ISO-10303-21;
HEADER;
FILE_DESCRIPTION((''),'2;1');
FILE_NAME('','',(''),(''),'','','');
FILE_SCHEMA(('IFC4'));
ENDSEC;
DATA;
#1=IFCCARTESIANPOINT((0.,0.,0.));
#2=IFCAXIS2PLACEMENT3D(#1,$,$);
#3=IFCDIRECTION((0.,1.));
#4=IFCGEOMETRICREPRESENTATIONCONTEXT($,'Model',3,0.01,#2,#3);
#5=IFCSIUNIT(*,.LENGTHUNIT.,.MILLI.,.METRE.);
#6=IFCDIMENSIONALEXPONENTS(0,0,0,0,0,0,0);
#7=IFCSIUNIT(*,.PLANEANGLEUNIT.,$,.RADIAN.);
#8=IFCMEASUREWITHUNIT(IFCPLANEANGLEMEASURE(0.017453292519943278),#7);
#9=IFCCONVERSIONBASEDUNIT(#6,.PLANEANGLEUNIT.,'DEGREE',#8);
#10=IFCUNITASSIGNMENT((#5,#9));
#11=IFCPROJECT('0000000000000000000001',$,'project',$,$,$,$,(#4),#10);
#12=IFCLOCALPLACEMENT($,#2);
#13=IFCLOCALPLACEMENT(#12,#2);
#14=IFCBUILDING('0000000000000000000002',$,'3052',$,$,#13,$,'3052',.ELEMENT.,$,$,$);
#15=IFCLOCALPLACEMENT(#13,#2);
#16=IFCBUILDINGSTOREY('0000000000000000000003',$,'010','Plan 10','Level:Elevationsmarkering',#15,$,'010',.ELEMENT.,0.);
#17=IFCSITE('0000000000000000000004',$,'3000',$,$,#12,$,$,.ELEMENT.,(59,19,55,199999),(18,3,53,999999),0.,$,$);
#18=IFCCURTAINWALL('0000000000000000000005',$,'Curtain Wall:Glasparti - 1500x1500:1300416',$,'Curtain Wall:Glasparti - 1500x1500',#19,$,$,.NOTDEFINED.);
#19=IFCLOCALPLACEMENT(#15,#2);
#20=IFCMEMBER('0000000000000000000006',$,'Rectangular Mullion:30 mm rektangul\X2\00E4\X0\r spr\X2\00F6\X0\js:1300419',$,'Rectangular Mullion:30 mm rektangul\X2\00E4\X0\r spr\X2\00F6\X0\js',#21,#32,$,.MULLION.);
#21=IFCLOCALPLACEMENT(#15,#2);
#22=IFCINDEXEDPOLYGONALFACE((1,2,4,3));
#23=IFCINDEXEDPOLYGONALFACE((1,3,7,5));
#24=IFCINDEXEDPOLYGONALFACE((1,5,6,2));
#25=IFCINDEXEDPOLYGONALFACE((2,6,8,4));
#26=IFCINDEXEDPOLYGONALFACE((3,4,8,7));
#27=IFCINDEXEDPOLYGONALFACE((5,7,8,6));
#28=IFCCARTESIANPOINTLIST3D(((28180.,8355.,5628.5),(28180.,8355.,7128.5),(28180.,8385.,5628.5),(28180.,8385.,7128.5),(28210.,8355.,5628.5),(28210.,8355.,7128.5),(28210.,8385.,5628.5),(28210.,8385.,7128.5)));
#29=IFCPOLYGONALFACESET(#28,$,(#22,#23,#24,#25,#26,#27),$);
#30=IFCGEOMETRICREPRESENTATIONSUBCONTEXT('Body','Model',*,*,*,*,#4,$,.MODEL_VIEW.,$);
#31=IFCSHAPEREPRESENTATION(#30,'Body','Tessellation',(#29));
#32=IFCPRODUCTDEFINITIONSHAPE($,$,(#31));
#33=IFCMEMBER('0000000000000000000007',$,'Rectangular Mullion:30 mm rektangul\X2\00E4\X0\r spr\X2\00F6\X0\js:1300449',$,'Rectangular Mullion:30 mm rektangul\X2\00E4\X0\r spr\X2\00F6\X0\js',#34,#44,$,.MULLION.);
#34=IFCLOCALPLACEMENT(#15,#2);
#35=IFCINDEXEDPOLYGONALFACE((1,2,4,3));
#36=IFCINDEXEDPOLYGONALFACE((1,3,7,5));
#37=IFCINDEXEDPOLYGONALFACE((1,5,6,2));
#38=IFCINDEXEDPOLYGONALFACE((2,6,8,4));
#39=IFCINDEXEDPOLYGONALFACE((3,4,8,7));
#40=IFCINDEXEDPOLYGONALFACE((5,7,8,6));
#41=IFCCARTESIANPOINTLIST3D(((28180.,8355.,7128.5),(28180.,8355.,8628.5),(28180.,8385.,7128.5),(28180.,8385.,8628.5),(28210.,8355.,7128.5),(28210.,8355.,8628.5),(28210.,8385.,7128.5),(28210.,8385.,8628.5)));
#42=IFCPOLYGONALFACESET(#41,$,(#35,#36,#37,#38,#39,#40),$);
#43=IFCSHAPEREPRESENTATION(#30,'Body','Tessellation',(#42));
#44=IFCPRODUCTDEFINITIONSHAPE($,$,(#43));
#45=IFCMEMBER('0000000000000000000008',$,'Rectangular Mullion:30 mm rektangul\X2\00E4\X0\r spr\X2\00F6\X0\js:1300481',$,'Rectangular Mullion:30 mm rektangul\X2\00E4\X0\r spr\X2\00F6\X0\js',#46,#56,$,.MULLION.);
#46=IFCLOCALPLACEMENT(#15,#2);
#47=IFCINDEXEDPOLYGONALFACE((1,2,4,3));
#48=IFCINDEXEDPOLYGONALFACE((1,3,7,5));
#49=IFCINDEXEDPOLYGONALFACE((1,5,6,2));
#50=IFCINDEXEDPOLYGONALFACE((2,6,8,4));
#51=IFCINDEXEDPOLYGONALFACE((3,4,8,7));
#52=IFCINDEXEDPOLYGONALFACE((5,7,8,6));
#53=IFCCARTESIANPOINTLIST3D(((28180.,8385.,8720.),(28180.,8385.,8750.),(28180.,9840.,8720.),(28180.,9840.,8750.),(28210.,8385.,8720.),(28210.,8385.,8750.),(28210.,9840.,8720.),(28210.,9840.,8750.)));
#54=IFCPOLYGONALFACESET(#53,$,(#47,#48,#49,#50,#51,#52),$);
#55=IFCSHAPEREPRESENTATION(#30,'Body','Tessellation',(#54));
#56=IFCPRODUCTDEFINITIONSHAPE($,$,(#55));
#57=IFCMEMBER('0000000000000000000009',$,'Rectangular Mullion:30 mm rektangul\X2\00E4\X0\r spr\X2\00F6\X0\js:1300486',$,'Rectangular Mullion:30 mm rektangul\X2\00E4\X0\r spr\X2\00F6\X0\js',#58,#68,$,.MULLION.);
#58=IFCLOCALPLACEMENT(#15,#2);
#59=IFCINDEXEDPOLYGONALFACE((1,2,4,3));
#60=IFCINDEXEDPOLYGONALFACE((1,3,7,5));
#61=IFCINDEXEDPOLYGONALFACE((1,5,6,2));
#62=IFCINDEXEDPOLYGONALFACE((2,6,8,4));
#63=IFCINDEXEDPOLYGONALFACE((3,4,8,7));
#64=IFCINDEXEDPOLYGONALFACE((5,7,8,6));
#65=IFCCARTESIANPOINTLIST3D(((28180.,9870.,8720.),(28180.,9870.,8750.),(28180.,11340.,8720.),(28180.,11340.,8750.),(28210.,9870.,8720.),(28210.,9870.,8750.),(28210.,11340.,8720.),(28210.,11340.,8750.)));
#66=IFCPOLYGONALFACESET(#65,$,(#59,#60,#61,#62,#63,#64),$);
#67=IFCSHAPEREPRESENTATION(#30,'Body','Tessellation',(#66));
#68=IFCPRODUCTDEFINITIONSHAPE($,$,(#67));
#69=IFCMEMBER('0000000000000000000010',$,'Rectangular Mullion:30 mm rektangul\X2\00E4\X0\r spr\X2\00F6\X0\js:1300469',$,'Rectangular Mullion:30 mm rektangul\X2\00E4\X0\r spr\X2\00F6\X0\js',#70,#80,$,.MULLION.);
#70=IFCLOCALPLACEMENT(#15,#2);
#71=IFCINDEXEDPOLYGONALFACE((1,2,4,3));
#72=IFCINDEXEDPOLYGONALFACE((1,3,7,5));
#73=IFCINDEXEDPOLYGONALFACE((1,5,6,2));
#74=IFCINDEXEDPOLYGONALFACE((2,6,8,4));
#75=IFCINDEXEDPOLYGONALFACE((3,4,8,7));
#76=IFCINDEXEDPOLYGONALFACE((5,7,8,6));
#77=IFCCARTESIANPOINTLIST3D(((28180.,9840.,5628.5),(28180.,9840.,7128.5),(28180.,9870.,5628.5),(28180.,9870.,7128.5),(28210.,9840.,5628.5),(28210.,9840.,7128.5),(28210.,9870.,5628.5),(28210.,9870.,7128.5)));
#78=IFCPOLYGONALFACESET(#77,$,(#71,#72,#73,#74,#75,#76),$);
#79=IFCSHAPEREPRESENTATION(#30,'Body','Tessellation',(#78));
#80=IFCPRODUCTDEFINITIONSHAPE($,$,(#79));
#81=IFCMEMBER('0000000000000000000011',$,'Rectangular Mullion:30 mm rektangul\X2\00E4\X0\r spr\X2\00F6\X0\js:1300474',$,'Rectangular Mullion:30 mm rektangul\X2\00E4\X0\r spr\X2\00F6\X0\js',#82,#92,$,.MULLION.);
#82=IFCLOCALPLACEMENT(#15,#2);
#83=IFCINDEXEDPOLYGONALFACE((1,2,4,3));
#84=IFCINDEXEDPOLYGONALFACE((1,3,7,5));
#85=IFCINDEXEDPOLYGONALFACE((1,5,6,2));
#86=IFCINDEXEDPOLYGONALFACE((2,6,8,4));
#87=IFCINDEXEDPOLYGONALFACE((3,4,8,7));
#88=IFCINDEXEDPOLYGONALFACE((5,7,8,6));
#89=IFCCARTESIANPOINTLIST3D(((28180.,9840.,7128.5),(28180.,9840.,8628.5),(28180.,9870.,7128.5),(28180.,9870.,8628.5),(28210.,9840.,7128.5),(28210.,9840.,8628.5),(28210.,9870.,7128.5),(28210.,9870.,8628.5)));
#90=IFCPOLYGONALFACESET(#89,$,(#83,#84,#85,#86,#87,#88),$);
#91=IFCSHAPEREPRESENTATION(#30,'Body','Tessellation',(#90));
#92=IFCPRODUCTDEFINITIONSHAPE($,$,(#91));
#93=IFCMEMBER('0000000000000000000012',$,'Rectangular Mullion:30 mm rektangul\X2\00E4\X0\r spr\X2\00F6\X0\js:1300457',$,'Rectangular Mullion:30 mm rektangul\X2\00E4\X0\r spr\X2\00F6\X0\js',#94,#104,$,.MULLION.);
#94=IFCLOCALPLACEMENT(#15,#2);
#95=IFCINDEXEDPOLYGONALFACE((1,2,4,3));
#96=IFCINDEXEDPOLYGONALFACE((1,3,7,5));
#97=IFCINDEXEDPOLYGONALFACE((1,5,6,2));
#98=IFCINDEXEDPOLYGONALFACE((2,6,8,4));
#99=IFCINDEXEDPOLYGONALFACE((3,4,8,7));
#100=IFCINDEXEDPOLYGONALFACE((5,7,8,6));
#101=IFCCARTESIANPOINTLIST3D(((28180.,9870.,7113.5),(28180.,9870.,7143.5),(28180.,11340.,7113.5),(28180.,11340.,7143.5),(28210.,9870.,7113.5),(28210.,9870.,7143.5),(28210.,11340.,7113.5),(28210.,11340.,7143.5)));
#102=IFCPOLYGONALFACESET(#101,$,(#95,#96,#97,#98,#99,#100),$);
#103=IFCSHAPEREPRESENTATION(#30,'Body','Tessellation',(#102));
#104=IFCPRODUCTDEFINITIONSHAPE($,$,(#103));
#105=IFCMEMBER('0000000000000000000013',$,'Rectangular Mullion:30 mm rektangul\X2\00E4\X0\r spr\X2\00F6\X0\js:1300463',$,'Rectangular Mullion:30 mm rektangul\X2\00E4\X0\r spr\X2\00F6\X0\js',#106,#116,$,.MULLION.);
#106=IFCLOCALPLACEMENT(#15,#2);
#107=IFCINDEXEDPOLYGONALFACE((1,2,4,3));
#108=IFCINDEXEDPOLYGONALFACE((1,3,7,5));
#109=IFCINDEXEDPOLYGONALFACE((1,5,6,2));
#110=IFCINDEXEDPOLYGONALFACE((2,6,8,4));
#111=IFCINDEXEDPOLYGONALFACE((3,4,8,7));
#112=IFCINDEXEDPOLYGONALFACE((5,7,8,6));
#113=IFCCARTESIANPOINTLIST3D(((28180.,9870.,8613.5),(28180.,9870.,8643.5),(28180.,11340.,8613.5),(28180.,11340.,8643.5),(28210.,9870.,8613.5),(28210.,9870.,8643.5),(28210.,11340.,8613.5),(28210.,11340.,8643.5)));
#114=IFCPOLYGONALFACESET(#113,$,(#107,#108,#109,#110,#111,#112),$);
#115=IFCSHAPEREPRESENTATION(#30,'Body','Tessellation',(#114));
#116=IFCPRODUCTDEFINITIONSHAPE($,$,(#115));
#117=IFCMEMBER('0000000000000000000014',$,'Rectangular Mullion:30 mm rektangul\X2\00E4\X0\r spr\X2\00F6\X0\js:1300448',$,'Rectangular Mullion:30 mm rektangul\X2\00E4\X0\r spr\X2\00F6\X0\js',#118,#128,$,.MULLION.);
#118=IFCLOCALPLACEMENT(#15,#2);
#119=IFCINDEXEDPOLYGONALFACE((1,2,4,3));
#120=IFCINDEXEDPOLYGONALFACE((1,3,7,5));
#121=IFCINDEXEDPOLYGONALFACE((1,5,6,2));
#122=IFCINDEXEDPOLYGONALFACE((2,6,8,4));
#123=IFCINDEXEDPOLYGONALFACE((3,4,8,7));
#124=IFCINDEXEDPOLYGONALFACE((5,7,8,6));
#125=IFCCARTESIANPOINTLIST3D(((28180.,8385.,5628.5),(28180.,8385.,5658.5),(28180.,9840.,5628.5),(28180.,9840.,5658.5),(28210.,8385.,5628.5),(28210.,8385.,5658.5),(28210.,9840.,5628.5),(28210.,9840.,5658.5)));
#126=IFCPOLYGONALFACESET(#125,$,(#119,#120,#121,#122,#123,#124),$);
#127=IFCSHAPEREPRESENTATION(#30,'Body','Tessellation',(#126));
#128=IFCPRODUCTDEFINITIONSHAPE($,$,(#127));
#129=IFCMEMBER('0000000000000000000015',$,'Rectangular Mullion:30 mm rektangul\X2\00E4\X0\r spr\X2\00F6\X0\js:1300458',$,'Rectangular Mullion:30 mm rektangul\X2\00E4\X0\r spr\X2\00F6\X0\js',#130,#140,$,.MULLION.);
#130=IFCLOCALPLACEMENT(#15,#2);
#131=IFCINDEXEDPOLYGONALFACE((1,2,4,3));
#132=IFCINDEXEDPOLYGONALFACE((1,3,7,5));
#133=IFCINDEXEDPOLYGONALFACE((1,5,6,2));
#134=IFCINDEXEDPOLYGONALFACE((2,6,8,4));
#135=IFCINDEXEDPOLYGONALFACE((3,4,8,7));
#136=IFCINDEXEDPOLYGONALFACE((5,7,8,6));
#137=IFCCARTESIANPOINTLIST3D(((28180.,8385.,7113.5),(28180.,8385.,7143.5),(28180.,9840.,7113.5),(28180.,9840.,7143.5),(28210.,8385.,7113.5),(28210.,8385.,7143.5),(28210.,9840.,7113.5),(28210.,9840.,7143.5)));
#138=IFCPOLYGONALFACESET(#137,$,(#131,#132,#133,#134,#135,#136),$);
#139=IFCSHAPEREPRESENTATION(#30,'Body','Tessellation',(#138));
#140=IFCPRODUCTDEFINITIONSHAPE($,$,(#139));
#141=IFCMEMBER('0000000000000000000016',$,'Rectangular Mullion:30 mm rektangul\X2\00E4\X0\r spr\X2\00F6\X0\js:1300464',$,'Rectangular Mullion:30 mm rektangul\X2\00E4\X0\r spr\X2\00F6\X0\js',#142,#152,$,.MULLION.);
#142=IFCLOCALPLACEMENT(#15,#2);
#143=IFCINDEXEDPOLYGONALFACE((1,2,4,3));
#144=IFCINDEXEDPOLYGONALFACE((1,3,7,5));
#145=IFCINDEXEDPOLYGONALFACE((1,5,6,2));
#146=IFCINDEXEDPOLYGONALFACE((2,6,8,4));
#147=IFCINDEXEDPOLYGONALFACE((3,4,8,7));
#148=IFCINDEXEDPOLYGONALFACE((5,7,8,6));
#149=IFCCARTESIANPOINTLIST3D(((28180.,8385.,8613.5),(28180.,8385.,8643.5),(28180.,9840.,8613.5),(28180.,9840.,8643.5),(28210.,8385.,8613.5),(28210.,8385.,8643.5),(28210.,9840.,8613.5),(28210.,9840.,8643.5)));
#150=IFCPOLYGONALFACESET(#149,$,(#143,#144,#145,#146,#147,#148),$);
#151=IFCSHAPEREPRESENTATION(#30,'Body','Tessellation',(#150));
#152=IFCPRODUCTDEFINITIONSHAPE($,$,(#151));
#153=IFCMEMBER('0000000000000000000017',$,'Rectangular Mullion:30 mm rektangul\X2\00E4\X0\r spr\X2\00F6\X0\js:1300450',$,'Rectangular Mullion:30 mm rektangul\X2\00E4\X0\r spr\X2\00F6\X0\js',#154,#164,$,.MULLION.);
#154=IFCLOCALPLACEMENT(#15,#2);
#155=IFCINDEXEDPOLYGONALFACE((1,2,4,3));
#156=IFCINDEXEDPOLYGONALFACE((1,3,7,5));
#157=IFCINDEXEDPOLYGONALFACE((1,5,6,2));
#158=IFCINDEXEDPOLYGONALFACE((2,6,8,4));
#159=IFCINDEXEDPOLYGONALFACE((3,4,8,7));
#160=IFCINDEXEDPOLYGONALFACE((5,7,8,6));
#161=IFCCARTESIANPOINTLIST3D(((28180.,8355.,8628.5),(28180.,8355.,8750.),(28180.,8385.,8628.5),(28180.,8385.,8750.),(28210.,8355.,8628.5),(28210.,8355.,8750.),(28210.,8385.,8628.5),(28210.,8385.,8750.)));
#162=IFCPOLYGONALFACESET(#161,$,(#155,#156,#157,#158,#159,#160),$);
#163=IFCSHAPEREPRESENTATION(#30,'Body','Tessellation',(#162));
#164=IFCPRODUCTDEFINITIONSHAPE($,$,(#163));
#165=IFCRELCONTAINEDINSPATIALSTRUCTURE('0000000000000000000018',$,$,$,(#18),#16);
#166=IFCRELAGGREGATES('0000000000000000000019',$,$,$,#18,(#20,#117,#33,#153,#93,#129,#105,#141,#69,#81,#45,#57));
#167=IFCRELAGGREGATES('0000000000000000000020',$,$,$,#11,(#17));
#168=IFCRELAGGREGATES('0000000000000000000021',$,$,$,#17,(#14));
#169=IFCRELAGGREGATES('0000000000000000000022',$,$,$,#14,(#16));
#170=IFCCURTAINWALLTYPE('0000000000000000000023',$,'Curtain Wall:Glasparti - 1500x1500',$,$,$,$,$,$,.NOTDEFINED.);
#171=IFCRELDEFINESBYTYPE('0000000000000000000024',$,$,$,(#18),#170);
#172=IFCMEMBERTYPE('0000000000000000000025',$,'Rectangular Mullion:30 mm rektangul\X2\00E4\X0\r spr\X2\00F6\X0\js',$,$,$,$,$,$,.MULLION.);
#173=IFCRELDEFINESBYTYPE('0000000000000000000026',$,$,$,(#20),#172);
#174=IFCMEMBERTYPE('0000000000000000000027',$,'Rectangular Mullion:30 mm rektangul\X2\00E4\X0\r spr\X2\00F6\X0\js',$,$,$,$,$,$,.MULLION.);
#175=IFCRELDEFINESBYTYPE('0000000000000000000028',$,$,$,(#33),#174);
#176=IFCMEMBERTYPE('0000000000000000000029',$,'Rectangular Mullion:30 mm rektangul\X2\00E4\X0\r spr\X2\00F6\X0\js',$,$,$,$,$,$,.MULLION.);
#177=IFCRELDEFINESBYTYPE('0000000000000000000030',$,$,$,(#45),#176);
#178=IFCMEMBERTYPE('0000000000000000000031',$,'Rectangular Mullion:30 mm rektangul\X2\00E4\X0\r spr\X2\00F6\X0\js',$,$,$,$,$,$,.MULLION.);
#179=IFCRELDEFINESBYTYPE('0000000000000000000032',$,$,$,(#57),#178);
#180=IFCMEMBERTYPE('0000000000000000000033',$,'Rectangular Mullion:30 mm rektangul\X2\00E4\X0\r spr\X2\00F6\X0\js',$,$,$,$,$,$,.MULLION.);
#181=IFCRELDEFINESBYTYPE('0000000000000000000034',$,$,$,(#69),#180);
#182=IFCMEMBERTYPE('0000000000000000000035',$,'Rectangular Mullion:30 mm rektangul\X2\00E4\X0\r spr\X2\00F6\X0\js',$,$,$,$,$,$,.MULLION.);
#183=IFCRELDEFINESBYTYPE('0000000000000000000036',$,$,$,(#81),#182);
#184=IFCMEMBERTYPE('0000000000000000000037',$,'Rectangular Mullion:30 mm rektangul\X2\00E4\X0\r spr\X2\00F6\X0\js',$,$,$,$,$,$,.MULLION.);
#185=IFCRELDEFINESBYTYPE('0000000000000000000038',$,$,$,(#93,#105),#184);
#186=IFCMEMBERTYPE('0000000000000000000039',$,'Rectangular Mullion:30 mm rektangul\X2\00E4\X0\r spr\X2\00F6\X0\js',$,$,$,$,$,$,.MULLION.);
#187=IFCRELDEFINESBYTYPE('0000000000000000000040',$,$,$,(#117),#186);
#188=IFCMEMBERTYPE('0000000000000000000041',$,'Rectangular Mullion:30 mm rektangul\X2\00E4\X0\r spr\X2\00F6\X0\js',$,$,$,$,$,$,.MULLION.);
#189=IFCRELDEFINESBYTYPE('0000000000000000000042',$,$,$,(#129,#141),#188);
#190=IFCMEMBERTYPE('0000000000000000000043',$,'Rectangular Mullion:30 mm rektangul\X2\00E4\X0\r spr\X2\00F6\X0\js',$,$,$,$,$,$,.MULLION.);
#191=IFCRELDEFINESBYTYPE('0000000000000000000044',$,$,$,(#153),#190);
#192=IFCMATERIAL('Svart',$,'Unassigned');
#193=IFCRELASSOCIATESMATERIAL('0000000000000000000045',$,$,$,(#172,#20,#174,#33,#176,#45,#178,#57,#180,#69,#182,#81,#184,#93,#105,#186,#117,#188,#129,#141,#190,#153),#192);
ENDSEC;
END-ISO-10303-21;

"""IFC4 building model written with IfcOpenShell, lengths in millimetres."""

from ifc_helpers import new_model, entity, si_unit, converted_unit, direction, frame, origin, place, context, subcontext, project, spatial, indexed_curve, outline, extrude, source, transform, mapped, material, type_object, type_shapes, element, aggregate, save


model = new_model("IFC4")

# Units and contexts
model_context = context("Model", 3, precision=0.01, world=origin(), true_north=direction((0.0, 1.0)))
body_context = subcontext(model_context, "Body", "Model", "MODEL_VIEW")
ifc_project = project(units=[si_unit("LENGTHUNIT", "METRE", prefix="MILLI"), converted_unit("PLANEANGLEUNIT", "DEGREE", entity("IfcPlaneAngleMeasure", 0.017453292519943278), si_unit("PLANEANGLEUNIT", "RADIAN"), dimensions=[0, 0, 0, 0, 0, 0, 0])], contexts=[model_context])

# Site, building, storey
site_placement = place(None, origin())
site = spatial("IfcSite", under=ifc_project, at=site_placement, Name="3000", CompositionType="ELEMENT", RefLatitude=(59, 19, 55, 199999), RefLongitude=(18, 3, 53, 999999), RefElevation=0.0)
building_placement = place(site_placement, origin())
building = spatial("IfcBuilding", under=site, at=building_placement, Name="3052", LongName="3052", CompositionType="ELEMENT")
storey_placement = place(building_placement, origin())
storey = spatial("IfcBuildingStorey", under=building, at=storey_placement, Name="010", Description="Plan 10", ObjectType="Level:Elevationsmarkering", LongName="010", CompositionType="ELEMENT", Elevation=0.0)

# Curtain wall, members
curtain_wall_type = type_object("IfcCurtainWallType", Name="Curtain Wall:Glasparti - 1500x1500", PredefinedType="NOTDEFINED")
curtain_wall_placement = place(storey_placement, origin())
curtain_wall = element("IfcCurtainWall", 1, at=curtain_wall_placement, inside=storey, type_object=curtain_wall_type, Name="Curtain Wall:Glasparti - 1500x1500:1300416", ObjectType="Curtain Wall:Glasparti - 1500x1500", PredefinedType="NOTDEFINED")
ifc_material_1 = material(Name="Svart", Category="Unassigned")
member_type_1 = type_object("IfcMemberType", Name="Rectangular Mullion:30 mm rektangulär spröjs", PredefinedType="MULLION", material=ifc_material_1)
shared_shape_1 = source(origin(), body_context, "Body", "SweptSolid", [
    extrude(outline(indexed_curve([(-15.0, -15.0), (15.0, -15.0), (15.0, 15.0), (-15.0, 15.0), (-15.0, -15.0)], self_intersect=False)), frame((-15.0, 0.0, -1500.0), z_axis=(0.0, 0.0, 1.0), x_axis=(-1.0, 0.0, 0.0)), (0.0, 0.0, 1.0), 1500.0),
])
type_shapes(member_type_1, [shared_shape_1])
member_1_placement = place(curtain_wall_placement, frame((28195.0, 8355.0, 5628.5), z_axis=(0.0, 0.0, -1.0), x_axis=(0.0, -1.0, 0.0)))
member_1 = element("IfcMember", 2, at=member_1_placement, type_object=member_type_1, material=ifc_material_1, Name="Rectangular Mullion:30 mm rektangulär spröjs:1300419", ObjectType="Rectangular Mullion:30 mm rektangulär spröjs", PredefinedType="MULLION", context=body_context, shape_type="MappedRepresentation", body=[
    mapped(shared_shape_1, transform((0.0, 0.0, 0.0), scale=1.0)),
])
member_type_2 = type_object("IfcMemberType", Name="Rectangular Mullion:30 mm rektangulär spröjs", PredefinedType="MULLION", material=ifc_material_1)
shared_shape_2 = source(origin(), body_context, "Body", "SweptSolid", [
    extrude(outline(indexed_curve([(-15.0, -15.0), (15.0, -15.0), (15.0, 15.0), (-15.0, 15.0), (-15.0, -15.0)], self_intersect=False)), frame((-15.0, 0.0, -1500.0), z_axis=(0.0, 0.0, 1.0), x_axis=(-1.0, 0.0, 0.0)), (0.0, 0.0, 1.0), 1500.0),
])
type_shapes(member_type_2, [shared_shape_2])
member_2_placement = place(curtain_wall_placement, frame((28195.0, 8355.0, 7128.5), z_axis=(0.0, 0.0, -1.0), x_axis=(0.0, -1.0, 0.0)))
member_2 = element("IfcMember", 3, at=member_2_placement, type_object=member_type_2, material=ifc_material_1, Name="Rectangular Mullion:30 mm rektangulär spröjs:1300449", ObjectType="Rectangular Mullion:30 mm rektangulär spröjs", PredefinedType="MULLION", context=body_context, shape_type="MappedRepresentation", body=[
    mapped(shared_shape_2, transform((0.0, 0.0, 0.0), scale=1.0)),
])
member_type_3 = type_object("IfcMemberType", Name="Rectangular Mullion:30 mm rektangulär spröjs", PredefinedType="MULLION", material=ifc_material_1)
shared_shape_3 = source(origin(), body_context, "Body", "SweptSolid", [
    extrude(outline(indexed_curve([(-15.0, -15.0), (15.0, -15.0), (15.0, 15.0), (-15.0, 15.0), (-15.0, -15.0)], self_intersect=False)), frame((-15.0, 0.0, -1455.0), z_axis=(0.0, 0.0, 1.0), x_axis=(-1.0, 0.0, 0.0)), (0.0, 0.0, 1.0), 1455.0),
])
type_shapes(member_type_3, [shared_shape_3])
member_3_placement = place(curtain_wall_placement, frame((28195.0, 8385.0, 8750.0), z_axis=(0.0, -1.0, 0.0), x_axis=(0.0, 0.0, 1.0)))
member_3 = element("IfcMember", 4, at=member_3_placement, type_object=member_type_3, material=ifc_material_1, Name="Rectangular Mullion:30 mm rektangulär spröjs:1300481", ObjectType="Rectangular Mullion:30 mm rektangulär spröjs", PredefinedType="MULLION", context=body_context, shape_type="MappedRepresentation", body=[
    mapped(shared_shape_3, transform((0.0, 0.0, 0.0), scale=1.0)),
])
member_type_4 = type_object("IfcMemberType", Name="Rectangular Mullion:30 mm rektangulär spröjs", PredefinedType="MULLION", material=ifc_material_1)
shared_shape_4 = source(origin(), body_context, "Body", "SweptSolid", [
    extrude(outline(indexed_curve([(-15.0, -15.0), (15.0, -15.0), (15.0, 15.0), (-15.0, 15.0), (-15.0, -15.0)], self_intersect=False)), frame((-15.0, 0.0, -1470.0), z_axis=(0.0, 0.0, 1.0), x_axis=(-1.0, 0.0, 0.0)), (0.0, 0.0, 1.0), 1470.0),
])
type_shapes(member_type_4, [shared_shape_4])
member_4_placement = place(curtain_wall_placement, frame((28195.0, 9870.0, 8750.0), z_axis=(0.0, -1.0, 0.0), x_axis=(0.0, 0.0, 1.0)))
member_4 = element("IfcMember", 5, at=member_4_placement, type_object=member_type_4, material=ifc_material_1, Name="Rectangular Mullion:30 mm rektangulär spröjs:1300486", ObjectType="Rectangular Mullion:30 mm rektangulär spröjs", PredefinedType="MULLION", context=body_context, shape_type="MappedRepresentation", body=[
    mapped(shared_shape_4, transform((0.0, 0.0, 0.0), scale=1.0)),
])
member_type_5 = type_object("IfcMemberType", Name="Rectangular Mullion:30 mm rektangulär spröjs", PredefinedType="MULLION", material=ifc_material_1)
shared_shape_5 = source(origin(), body_context, "Body", "SweptSolid", [
    extrude(outline(indexed_curve([(-15.0, -15.0), (15.0, -15.0), (15.0, 15.0), (-15.0, 15.0), (-15.0, -15.0)], self_intersect=False)), frame((0.0, 0.0, -1500.0), z_axis=(0.0, 0.0, 1.0), x_axis=(-1.0, 0.0, 0.0)), (0.0, 0.0, 1.0), 1500.0),
])
type_shapes(member_type_5, [shared_shape_5])
member_5_placement = place(curtain_wall_placement, frame((28195.0, 9855.0, 5628.5), z_axis=(0.0, 0.0, -1.0), x_axis=(0.0, -1.0, 0.0)))
member_5 = element("IfcMember", 6, at=member_5_placement, type_object=member_type_5, material=ifc_material_1, Name="Rectangular Mullion:30 mm rektangulär spröjs:1300469", ObjectType="Rectangular Mullion:30 mm rektangulär spröjs", PredefinedType="MULLION", context=body_context, shape_type="MappedRepresentation", body=[
    mapped(shared_shape_5, transform((0.0, 0.0, 0.0), scale=1.0)),
])
member_type_6 = type_object("IfcMemberType", Name="Rectangular Mullion:30 mm rektangulär spröjs", PredefinedType="MULLION", material=ifc_material_1)
shared_shape_6 = source(origin(), body_context, "Body", "SweptSolid", [
    extrude(outline(indexed_curve([(-15.0, -15.0), (15.0, -15.0), (15.0, 15.0), (-15.0, 15.0), (-15.0, -15.0)], self_intersect=False)), frame((0.0, 0.0, -1500.0), z_axis=(0.0, 0.0, 1.0), x_axis=(-1.0, 0.0, 0.0)), (0.0, 0.0, 1.0), 1500.0),
])
type_shapes(member_type_6, [shared_shape_6])
member_6_placement = place(curtain_wall_placement, frame((28195.0, 9855.0, 7128.5), z_axis=(0.0, 0.0, -1.0), x_axis=(0.0, -1.0, 0.0)))
member_6 = element("IfcMember", 7, at=member_6_placement, type_object=member_type_6, material=ifc_material_1, Name="Rectangular Mullion:30 mm rektangulär spröjs:1300474", ObjectType="Rectangular Mullion:30 mm rektangulär spröjs", PredefinedType="MULLION", context=body_context, shape_type="MappedRepresentation", body=[
    mapped(shared_shape_6, transform((0.0, 0.0, 0.0), scale=1.0)),
])
member_type_7 = type_object("IfcMemberType", Name="Rectangular Mullion:30 mm rektangulär spröjs", PredefinedType="MULLION", material=ifc_material_1)
shared_shape_7 = source(origin(), body_context, "Body", "SweptSolid", [
    extrude(outline(indexed_curve([(-15.0, -15.0), (15.0, -15.0), (15.0, 15.0), (-15.0, 15.0), (-15.0, -15.0)], self_intersect=False)), frame((0.0, 0.0, -1470.0), z_axis=(0.0, 0.0, 1.0), x_axis=(-1.0, 0.0, 0.0)), (0.0, 0.0, 1.0), 1470.0),
])
type_shapes(member_type_7, [shared_shape_7])
member_7_placement = place(curtain_wall_placement, frame((28195.0, 9870.0, 7128.5), z_axis=(0.0, -1.0, 0.0), x_axis=(0.0, 0.0, 1.0)))
member_7 = element("IfcMember", 8, at=member_7_placement, type_object=member_type_7, material=ifc_material_1, Name="Rectangular Mullion:30 mm rektangulär spröjs:1300457", ObjectType="Rectangular Mullion:30 mm rektangulär spröjs", PredefinedType="MULLION", context=body_context, shape_type="MappedRepresentation", body=[
    mapped(shared_shape_7, transform((0.0, 0.0, 0.0), scale=1.0)),
])
member_8_placement = place(curtain_wall_placement, frame((28195.0, 9870.0, 8628.5), z_axis=(0.0, -1.0, 0.0), x_axis=(0.0, 0.0, 1.0)))
member_8 = element("IfcMember", 9, at=member_8_placement, type_object=member_type_7, material=ifc_material_1, Name="Rectangular Mullion:30 mm rektangulär spröjs:1300463", ObjectType="Rectangular Mullion:30 mm rektangulär spröjs", PredefinedType="MULLION", context=body_context, shape_type="MappedRepresentation", body=[
    mapped(shared_shape_7, transform((0.0, 0.0, 0.0), scale=1.0)),
])
member_type_8 = type_object("IfcMemberType", Name="Rectangular Mullion:30 mm rektangulär spröjs", PredefinedType="MULLION", material=ifc_material_1)
shared_shape_8 = source(origin(), body_context, "Body", "SweptSolid", [
    extrude(outline(indexed_curve([(-15.0, -15.0), (15.0, -15.0), (15.0, 15.0), (-15.0, 15.0), (-15.0, -15.0)], self_intersect=False)), frame((-15.0, 0.0, -1455.0), z_axis=(0.0, 0.0, 1.0), x_axis=(-1.0, 0.0, 0.0)), (0.0, 0.0, 1.0), 1455.0),
])
type_shapes(member_type_8, [shared_shape_8])
member_9_placement = place(curtain_wall_placement, frame((28195.0, 9840.0, 5628.5), z_axis=(0.0, 1.0, 0.0), x_axis=(0.0, 0.0, -1.0)))
member_9 = element("IfcMember", 10, at=member_9_placement, type_object=member_type_8, material=ifc_material_1, Name="Rectangular Mullion:30 mm rektangulär spröjs:1300448", ObjectType="Rectangular Mullion:30 mm rektangulär spröjs", PredefinedType="MULLION", context=body_context, shape_type="MappedRepresentation", body=[
    mapped(shared_shape_8, transform((0.0, 0.0, 0.0), scale=1.0)),
])
member_type_9 = type_object("IfcMemberType", Name="Rectangular Mullion:30 mm rektangulär spröjs", PredefinedType="MULLION", material=ifc_material_1)
shared_shape_9 = source(origin(), body_context, "Body", "SweptSolid", [
    extrude(outline(indexed_curve([(-15.0, -15.0), (15.0, -15.0), (15.0, 15.0), (-15.0, 15.0), (-15.0, -15.0)], self_intersect=False)), frame((0.0, 0.0, -1455.0), z_axis=(0.0, 0.0, 1.0), x_axis=(-1.0, 0.0, 0.0)), (0.0, 0.0, 1.0), 1455.0),
])
type_shapes(member_type_9, [shared_shape_9])
member_10_placement = place(curtain_wall_placement, frame((28195.0, 8385.0, 7128.5), z_axis=(0.0, -1.0, 0.0), x_axis=(0.0, 0.0, 1.0)))
member_10 = element("IfcMember", 11, at=member_10_placement, type_object=member_type_9, material=ifc_material_1, Name="Rectangular Mullion:30 mm rektangulär spröjs:1300458", ObjectType="Rectangular Mullion:30 mm rektangulär spröjs", PredefinedType="MULLION", context=body_context, shape_type="MappedRepresentation", body=[
    mapped(shared_shape_9, transform((0.0, 0.0, 0.0), scale=1.0)),
])
member_11_placement = place(curtain_wall_placement, frame((28195.0, 8385.0, 8628.5), z_axis=(0.0, -1.0, 0.0), x_axis=(0.0, 0.0, 1.0)))
member_11 = element("IfcMember", 12, at=member_11_placement, type_object=member_type_9, material=ifc_material_1, Name="Rectangular Mullion:30 mm rektangulär spröjs:1300464", ObjectType="Rectangular Mullion:30 mm rektangulär spröjs", PredefinedType="MULLION", context=body_context, shape_type="MappedRepresentation", body=[
    mapped(shared_shape_9, transform((0.0, 0.0, 0.0), scale=1.0)),
])
member_type_10 = type_object("IfcMemberType", Name="Rectangular Mullion:30 mm rektangulär spröjs", PredefinedType="MULLION", material=ifc_material_1)
shared_shape_10 = source(origin(), body_context, "Body", "SweptSolid", [
    extrude(outline(indexed_curve([(-15.0, -15.0), (15.0, -15.0), (15.0, 15.0), (-15.0, 15.0), (-15.0, -15.0)], self_intersect=False)), frame((-15.0, 0.0, -121.5), z_axis=(0.0, 0.0, 1.0), x_axis=(-1.0, 0.0, 0.0)), (0.0, 0.0, 1.0), 121.5),
])
type_shapes(member_type_10, [shared_shape_10])
member_12_placement = place(curtain_wall_placement, frame((28195.0, 8355.0, 8628.5), z_axis=(0.0, 0.0, -1.0), x_axis=(0.0, -1.0, 0.0)))
member_12 = element("IfcMember", 13, at=member_12_placement, type_object=member_type_10, material=ifc_material_1, Name="Rectangular Mullion:30 mm rektangulär spröjs:1300450", ObjectType="Rectangular Mullion:30 mm rektangulär spröjs", PredefinedType="MULLION", context=body_context, shape_type="MappedRepresentation", body=[
    mapped(shared_shape_10, transform((0.0, 0.0, 0.0), scale=1.0)),
])
aggregate(curtain_wall, [member_1, member_9, member_2, member_12, member_7, member_10, member_8, member_11, member_5, member_6, member_3, member_4])

save(model, "model.ifc")
